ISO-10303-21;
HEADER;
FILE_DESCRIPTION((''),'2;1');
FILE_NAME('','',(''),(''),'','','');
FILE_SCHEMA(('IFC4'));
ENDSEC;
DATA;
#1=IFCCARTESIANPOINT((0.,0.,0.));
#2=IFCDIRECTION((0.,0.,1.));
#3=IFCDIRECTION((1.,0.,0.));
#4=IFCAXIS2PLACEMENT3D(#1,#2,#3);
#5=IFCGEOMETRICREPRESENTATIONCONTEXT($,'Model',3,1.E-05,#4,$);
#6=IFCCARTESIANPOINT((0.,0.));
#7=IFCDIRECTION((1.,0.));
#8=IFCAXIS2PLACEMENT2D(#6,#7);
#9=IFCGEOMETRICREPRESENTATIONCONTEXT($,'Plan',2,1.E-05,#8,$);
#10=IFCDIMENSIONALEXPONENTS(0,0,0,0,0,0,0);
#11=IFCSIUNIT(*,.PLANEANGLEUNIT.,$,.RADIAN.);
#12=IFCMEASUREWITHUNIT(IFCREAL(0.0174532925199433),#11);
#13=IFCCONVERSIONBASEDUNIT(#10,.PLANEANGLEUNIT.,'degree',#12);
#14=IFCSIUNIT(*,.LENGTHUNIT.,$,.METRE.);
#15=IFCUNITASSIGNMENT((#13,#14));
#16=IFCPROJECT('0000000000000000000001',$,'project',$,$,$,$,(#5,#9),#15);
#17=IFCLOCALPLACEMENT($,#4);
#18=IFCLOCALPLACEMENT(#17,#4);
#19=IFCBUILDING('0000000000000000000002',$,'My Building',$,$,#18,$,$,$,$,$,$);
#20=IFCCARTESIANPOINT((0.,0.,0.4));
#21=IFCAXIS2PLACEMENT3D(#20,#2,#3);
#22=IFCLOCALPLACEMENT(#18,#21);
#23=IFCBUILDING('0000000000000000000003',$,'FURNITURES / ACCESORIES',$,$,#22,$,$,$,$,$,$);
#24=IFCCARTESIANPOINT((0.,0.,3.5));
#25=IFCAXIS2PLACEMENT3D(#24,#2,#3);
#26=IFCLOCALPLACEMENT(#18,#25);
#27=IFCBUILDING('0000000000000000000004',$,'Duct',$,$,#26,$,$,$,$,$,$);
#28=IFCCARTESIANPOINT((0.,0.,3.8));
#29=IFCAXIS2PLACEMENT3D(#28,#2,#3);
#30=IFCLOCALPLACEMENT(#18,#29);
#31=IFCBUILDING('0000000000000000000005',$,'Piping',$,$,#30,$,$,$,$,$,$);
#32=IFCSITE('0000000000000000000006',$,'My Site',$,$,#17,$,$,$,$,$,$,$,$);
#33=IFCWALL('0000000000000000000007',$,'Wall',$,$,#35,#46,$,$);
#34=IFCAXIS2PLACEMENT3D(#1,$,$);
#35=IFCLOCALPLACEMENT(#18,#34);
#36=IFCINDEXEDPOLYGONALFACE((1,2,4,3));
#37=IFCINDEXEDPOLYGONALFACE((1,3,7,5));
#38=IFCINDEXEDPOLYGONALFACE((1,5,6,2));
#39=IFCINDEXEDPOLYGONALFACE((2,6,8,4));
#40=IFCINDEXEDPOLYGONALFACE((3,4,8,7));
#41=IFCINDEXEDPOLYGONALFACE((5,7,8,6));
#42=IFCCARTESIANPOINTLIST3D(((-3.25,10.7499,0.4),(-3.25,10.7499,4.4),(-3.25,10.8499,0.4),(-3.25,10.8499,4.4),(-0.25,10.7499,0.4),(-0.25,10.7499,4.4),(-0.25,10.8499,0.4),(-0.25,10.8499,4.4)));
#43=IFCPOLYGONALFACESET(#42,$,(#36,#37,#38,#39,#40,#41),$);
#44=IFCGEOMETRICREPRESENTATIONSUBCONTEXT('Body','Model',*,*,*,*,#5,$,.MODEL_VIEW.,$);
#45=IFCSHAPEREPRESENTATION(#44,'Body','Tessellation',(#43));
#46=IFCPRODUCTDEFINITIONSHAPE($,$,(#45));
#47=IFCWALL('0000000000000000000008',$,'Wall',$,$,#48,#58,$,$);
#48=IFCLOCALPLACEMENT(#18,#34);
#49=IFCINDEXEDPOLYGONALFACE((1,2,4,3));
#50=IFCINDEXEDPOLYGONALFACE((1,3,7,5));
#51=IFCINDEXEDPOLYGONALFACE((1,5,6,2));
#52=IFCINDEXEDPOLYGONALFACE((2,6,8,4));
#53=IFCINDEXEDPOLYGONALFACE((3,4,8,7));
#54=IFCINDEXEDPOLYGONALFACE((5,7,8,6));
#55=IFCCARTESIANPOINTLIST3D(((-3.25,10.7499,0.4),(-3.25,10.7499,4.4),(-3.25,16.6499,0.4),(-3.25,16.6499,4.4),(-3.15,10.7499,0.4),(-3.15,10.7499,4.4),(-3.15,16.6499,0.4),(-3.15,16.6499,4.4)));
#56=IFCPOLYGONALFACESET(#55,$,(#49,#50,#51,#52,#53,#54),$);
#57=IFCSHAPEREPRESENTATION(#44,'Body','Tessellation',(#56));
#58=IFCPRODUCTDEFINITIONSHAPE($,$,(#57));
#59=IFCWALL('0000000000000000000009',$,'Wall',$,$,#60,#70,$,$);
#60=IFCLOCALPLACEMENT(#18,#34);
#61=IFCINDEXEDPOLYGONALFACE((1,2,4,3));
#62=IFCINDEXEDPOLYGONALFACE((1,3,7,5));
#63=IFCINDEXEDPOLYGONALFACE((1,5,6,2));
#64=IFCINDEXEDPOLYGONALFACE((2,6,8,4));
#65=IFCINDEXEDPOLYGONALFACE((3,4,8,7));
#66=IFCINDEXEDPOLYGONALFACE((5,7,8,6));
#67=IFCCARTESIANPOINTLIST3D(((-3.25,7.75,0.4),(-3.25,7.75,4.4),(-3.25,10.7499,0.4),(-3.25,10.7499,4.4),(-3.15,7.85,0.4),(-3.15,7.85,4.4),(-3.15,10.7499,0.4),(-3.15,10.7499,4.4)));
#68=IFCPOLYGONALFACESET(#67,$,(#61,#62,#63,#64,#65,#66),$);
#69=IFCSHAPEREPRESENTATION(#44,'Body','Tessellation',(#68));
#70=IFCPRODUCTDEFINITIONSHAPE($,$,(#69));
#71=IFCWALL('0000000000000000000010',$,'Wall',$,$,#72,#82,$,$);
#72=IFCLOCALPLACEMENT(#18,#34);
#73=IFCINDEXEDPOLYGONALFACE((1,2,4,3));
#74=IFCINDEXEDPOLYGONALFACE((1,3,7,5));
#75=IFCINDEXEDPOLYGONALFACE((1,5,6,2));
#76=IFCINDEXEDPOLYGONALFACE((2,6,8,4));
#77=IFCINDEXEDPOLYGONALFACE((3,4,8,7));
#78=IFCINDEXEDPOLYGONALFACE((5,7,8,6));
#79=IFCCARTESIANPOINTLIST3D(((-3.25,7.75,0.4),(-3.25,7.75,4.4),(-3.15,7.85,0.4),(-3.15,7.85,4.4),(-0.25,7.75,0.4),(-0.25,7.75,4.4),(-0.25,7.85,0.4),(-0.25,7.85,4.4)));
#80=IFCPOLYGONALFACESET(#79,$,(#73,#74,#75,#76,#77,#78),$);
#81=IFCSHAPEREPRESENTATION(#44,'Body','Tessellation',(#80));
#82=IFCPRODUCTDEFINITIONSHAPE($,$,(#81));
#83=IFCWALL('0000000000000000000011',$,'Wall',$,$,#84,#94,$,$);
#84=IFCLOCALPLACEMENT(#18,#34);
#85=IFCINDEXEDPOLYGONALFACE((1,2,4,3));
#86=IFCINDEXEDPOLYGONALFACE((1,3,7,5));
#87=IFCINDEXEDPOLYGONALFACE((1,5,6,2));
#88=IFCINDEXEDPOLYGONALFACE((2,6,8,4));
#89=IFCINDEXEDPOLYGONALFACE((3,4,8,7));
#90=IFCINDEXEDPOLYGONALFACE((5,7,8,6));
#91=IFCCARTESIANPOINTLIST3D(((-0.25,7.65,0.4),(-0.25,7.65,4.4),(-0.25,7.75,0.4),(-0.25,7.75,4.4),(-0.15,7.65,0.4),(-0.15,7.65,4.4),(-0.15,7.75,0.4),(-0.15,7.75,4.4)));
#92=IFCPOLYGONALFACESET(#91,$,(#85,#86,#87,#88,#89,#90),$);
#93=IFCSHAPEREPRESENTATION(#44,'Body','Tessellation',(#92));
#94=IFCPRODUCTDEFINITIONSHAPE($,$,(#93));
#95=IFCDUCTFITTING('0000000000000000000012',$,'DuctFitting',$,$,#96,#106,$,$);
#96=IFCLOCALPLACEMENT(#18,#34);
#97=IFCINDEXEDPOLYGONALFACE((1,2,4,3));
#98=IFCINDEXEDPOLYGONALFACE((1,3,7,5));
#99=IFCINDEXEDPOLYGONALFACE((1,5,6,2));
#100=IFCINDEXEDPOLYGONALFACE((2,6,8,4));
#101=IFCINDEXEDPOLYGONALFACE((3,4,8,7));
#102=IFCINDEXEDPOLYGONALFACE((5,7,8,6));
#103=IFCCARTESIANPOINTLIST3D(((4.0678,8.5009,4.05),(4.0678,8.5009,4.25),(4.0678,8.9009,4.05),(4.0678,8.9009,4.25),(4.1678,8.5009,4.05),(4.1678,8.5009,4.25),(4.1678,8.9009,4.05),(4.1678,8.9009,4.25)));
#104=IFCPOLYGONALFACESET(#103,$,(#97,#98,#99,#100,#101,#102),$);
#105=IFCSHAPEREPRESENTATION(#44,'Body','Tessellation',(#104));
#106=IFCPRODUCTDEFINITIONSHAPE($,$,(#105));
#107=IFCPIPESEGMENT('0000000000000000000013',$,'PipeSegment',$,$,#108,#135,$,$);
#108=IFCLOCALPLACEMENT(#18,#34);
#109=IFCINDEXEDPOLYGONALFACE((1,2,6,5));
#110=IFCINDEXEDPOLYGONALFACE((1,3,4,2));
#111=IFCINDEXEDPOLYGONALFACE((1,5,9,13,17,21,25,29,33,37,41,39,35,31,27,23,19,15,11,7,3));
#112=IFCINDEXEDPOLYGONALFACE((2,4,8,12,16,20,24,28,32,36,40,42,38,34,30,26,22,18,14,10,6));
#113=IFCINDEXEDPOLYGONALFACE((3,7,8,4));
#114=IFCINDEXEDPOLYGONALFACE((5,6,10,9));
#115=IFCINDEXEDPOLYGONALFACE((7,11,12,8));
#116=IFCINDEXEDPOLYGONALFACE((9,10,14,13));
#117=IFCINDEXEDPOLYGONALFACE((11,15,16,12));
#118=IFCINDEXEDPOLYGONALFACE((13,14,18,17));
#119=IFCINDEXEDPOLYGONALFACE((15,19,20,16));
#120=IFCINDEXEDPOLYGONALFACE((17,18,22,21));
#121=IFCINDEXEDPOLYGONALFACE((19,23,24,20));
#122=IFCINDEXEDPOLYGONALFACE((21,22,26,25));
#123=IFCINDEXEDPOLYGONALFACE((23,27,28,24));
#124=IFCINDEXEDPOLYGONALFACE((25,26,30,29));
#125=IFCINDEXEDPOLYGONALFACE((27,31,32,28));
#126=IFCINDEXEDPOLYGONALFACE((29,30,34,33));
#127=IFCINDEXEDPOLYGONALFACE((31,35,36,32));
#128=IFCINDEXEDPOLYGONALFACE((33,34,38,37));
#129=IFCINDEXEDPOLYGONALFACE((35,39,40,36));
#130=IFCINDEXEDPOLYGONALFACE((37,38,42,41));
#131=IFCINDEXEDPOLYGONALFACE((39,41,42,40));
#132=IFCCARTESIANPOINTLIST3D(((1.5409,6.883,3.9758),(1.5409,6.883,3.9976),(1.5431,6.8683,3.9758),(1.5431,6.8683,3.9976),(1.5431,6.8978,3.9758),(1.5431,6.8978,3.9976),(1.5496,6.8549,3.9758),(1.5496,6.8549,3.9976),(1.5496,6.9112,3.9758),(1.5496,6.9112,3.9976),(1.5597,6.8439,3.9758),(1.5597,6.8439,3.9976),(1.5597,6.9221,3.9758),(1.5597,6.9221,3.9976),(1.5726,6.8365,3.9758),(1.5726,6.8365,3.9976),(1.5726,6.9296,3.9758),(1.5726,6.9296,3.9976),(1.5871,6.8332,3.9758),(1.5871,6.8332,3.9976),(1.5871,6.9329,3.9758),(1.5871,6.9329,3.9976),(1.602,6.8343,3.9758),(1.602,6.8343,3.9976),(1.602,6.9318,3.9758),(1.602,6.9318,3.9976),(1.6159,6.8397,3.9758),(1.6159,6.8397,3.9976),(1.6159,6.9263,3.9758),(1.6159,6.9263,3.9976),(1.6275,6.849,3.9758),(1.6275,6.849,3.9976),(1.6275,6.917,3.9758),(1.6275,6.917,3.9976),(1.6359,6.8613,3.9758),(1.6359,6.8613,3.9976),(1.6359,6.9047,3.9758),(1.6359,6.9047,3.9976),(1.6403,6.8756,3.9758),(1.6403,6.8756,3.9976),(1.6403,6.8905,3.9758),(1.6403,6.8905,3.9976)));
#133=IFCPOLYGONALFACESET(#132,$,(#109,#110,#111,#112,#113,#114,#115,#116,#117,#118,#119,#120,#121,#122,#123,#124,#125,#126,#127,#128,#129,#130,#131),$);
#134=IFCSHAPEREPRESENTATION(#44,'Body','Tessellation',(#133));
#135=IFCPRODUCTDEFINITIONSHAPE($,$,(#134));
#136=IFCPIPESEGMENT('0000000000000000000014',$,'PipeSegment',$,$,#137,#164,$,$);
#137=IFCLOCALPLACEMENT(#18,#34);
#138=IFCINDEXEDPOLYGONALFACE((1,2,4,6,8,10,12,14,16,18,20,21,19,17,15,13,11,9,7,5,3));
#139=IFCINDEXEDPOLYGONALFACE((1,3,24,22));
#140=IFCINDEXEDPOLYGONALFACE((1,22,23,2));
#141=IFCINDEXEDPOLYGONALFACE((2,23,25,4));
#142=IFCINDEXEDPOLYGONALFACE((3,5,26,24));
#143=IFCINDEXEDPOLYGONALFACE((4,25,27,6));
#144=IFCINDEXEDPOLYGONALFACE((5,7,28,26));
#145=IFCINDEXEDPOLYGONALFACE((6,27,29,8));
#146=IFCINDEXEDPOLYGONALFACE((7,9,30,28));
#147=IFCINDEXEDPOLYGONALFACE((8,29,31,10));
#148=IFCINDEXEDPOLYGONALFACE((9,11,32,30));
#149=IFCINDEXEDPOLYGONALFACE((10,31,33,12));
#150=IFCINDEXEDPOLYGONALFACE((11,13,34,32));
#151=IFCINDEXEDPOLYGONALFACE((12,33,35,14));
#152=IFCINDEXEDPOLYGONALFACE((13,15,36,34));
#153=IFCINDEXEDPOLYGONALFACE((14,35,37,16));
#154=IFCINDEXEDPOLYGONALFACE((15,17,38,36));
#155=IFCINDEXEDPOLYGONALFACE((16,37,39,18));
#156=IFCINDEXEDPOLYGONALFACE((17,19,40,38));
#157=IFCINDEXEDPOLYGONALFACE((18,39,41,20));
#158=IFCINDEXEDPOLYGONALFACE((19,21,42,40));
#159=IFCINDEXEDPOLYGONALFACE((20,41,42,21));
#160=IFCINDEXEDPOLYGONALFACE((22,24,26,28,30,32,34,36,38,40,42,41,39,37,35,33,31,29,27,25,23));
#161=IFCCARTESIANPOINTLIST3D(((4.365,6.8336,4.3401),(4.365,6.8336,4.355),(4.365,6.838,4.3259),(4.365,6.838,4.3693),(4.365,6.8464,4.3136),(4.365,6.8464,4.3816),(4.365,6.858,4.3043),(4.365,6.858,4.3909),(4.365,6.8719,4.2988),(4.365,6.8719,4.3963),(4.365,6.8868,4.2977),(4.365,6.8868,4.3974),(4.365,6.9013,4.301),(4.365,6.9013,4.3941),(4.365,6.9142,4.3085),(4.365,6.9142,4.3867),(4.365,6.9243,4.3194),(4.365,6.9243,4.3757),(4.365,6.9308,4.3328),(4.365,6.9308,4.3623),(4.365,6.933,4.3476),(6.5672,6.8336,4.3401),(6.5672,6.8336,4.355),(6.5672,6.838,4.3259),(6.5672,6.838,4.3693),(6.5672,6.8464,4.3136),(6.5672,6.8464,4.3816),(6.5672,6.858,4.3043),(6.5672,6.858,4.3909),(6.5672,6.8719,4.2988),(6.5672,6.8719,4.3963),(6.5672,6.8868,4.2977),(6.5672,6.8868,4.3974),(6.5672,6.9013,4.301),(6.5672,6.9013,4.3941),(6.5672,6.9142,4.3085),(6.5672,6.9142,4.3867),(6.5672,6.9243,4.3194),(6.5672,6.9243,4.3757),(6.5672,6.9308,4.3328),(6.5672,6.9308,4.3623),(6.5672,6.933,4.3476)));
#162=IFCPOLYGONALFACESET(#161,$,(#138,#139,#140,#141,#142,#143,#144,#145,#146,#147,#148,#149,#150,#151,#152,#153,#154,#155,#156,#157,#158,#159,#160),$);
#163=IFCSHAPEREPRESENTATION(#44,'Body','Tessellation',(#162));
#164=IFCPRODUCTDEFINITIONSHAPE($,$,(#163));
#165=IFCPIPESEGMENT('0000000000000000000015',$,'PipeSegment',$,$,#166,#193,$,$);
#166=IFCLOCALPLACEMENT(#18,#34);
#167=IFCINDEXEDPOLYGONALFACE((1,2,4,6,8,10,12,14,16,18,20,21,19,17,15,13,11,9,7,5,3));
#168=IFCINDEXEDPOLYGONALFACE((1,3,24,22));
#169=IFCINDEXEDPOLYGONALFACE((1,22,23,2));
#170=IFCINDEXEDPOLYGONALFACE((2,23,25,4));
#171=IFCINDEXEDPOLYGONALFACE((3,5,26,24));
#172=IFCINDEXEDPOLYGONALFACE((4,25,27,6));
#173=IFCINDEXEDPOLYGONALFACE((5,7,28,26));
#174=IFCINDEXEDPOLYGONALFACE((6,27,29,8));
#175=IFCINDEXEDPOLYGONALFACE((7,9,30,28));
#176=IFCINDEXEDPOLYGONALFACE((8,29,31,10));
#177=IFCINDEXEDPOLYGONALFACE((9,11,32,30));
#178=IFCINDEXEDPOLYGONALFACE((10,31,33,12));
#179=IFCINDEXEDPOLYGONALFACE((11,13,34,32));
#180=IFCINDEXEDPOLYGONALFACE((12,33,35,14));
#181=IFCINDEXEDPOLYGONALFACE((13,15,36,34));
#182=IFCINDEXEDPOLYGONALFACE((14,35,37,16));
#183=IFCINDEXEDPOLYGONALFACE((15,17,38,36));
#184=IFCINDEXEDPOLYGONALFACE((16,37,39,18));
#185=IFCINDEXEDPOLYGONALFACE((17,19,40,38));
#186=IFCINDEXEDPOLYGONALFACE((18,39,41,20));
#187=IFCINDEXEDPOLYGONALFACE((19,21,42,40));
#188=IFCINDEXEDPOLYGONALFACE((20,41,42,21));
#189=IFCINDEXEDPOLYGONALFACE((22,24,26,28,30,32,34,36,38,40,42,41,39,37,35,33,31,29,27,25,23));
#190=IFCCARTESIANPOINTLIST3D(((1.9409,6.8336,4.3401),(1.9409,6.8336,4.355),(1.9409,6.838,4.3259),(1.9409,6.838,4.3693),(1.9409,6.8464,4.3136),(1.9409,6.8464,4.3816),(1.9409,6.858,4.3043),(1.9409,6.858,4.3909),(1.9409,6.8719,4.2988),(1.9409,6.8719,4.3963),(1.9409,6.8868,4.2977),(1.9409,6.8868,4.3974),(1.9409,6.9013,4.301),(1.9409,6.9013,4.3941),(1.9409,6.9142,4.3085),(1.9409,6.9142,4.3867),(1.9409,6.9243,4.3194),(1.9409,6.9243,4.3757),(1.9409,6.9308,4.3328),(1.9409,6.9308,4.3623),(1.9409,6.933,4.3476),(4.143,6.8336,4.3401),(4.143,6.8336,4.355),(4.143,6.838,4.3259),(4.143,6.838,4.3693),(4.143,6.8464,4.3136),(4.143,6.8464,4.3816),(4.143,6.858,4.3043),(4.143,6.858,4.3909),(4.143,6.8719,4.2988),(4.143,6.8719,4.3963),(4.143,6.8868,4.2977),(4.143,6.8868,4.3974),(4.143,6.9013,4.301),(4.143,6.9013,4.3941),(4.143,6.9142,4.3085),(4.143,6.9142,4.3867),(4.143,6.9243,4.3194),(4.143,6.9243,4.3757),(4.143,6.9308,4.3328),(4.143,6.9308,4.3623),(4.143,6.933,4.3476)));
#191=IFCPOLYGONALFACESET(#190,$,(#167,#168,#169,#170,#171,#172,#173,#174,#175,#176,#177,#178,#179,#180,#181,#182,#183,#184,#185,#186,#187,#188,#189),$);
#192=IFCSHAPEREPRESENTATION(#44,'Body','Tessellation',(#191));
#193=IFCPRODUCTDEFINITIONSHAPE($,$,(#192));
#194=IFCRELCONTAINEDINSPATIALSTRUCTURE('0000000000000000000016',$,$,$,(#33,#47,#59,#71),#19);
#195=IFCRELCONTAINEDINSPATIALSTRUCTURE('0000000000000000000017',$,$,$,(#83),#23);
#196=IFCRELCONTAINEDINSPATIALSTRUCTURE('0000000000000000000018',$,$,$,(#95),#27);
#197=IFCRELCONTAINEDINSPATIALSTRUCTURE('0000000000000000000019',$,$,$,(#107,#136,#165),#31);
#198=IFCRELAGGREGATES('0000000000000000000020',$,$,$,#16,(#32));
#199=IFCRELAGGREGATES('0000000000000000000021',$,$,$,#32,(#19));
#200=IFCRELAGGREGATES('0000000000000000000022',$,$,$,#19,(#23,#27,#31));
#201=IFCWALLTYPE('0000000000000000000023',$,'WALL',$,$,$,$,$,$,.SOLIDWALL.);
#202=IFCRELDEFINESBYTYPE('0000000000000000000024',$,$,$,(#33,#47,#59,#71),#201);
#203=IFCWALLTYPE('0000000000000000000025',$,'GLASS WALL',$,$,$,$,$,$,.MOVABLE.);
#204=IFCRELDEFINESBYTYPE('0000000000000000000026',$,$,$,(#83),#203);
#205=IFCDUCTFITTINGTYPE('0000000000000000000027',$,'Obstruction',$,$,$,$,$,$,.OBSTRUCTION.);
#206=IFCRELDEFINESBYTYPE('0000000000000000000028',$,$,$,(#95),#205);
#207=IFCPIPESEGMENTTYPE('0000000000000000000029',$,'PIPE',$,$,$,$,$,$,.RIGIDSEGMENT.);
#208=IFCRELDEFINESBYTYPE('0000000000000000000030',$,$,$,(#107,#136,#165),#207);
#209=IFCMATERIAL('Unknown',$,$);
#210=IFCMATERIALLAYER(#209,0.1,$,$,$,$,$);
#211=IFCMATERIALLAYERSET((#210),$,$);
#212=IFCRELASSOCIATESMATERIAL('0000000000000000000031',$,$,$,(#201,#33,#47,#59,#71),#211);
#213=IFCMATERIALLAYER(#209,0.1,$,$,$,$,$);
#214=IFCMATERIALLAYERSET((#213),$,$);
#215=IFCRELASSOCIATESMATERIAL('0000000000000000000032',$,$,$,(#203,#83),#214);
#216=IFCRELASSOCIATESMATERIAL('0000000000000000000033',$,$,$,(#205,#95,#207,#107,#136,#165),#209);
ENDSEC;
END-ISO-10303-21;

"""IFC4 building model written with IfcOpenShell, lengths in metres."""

from ifc_helpers import new_model, entity, si_unit, converted_unit, frame, origin_with_axes, origin_2d_with_axis, place, context, subcontext, project, spatial, line, indexed_curve, rectangle, circle, outline, extrude, material, layer, layer_set, layer_usage, material_profile, profile_set, profile_usage, type_object, element, save


model = new_model("IFC4")

# Units and contexts
model_context = context("Model", 3, precision=1e-05, world=origin_with_axes())
plan_context = context("Plan", 2, precision=1e-05, world=origin_2d_with_axis())
body_context = subcontext(model_context, "Body", "Model", "MODEL_VIEW")
ifc_project = project(units=[converted_unit("PLANEANGLEUNIT", "degree", entity("IfcReal", 0.0174532925199433), si_unit("PLANEANGLEUNIT", "RADIAN"), dimensions=[0, 0, 0, 0, 0, 0, 0]), si_unit("LENGTHUNIT", "METRE")], contexts=[model_context, plan_context])

# Site, building
site_placement = place(None, origin_with_axes())
site = spatial("IfcSite", under=ifc_project, at=site_placement, Name="My Site")
building_1_placement = place(site_placement, origin_with_axes())
building_1 = spatial("IfcBuilding", under=site, at=building_1_placement, Name="My Building")

# Walls
ifc_material = material(Name="Unknown")
ifc_layer_1 = layer(ifc_material, 0.1)
ifc_layer_set_1 = layer_set([ifc_layer_1])
ifc_layer_usage_1 = layer_usage(ifc_layer_set_1, "AXIS2", "POSITIVE", 0.0)
wall_type_1 = type_object("IfcWallType", Name="WALL", PredefinedType="SOLIDWALL", material=ifc_layer_set_1)
wall_1_placement = place(building_1_placement, frame((-3.25, 10.7499, 0.4), z_axis=(0.0, 0.0, 1.0), x_axis=(1.0, 0.0, 0.0)))
element("IfcWall", 1, at=wall_1_placement, inside=building_1, type_object=wall_type_1, material=ifc_layer_usage_1, Name="Wall", context=body_context, shape_type="SweptSolid", body=[
    extrude(outline(indexed_curve([(0.0, 0.0), (0.0, 0.1), (3.0, 0.1), (3.0, 0.0)], segments=[line(1, 2, 3, 4, 1)])), origin_with_axes(), (0.0, 0.0, 1.0), 4.0),
])
ifc_layer_usage_2 = layer_usage(ifc_layer_set_1, "AXIS2", "POSITIVE", 0.0)
wall_2_placement = place(building_1_placement, frame((-3.15, 10.7499, 0.4), z_axis=(0.0, 0.0, 1.0), x_axis=(0.0, 1.0, 0.0)))
element("IfcWall", 2, at=wall_2_placement, inside=building_1, type_object=wall_type_1, material=ifc_layer_usage_2, Name="Wall", context=body_context, shape_type="SweptSolid", body=[
    extrude(outline(indexed_curve([(0.0, 0.0), (0.0, 0.1), (5.9, 0.1), (5.9, 0.0)], segments=[line(1, 2, 3, 4, 1)])), origin_with_axes(), (0.0, 0.0, 1.0), 4.0),
])
ifc_layer_usage_3 = layer_usage(ifc_layer_set_1, "AXIS2", "POSITIVE", 0.0)
wall_3_placement = place(building_1_placement, frame((-3.25, 10.7499, 0.4), z_axis=(0.0, 0.0, 1.0), x_axis=(0.0, -1.0, 0.0)))
element("IfcWall", 3, at=wall_3_placement, inside=building_1, type_object=wall_type_1, material=ifc_layer_usage_3, Name="Wall", context=body_context, shape_type="SweptSolid", body=[
    extrude(outline(indexed_curve([(0.0, 0.0), (0.0, 0.1), (2.8999, 0.1), (2.9999, 0.0)], segments=[line(1, 2, 3, 4, 1)])), origin_with_axes(), (0.0, 0.0, 1.0), 4.0),
])
ifc_layer_usage_4 = layer_usage(ifc_layer_set_1, "AXIS2", "POSITIVE", 0.0)
wall_4_placement = place(building_1_placement, frame((-3.25, 7.75, 0.4), z_axis=(0.0, 0.0, 1.0), x_axis=(1.0, 0.0, 0.0)))
element("IfcWall", 4, at=wall_4_placement, inside=building_1, type_object=wall_type_1, material=ifc_layer_usage_4, Name="Wall", context=body_context, shape_type="SweptSolid", body=[
    extrude(outline(indexed_curve([(0.0, 0.0), (0.1, 0.1), (3.0, 0.1), (3.0, 0.0)], segments=[line(1, 2, 3, 4, 1)])), origin_with_axes(), (0.0, 0.0, 1.0), 4.0),
])

# Shared definitions
building_2_placement = place(building_1_placement, frame((0.0, 0.0, 0.4), z_axis=(0.0, 0.0, 1.0), x_axis=(1.0, 0.0, 0.0)))
building_2 = spatial("IfcBuilding", under=building_1, at=building_2_placement, Name="FURNITURES / ACCESORIES")

# Wall
ifc_layer_2 = layer(ifc_material, 0.1)
ifc_layer_set_2 = layer_set([ifc_layer_2])
ifc_layer_usage_5 = layer_usage(ifc_layer_set_2, "AXIS2", "POSITIVE", 0.0)
wall_type_2 = type_object("IfcWallType", Name="GLASS WALL", PredefinedType="MOVABLE", material=ifc_layer_set_2)
wall_5_placement = place(building_2_placement, frame((-0.25, 7.65, 0.0), z_axis=(0.0, 0.0, 1.0), x_axis=(1.0, 0.0, 0.0)))
element("IfcWall", 5, at=wall_5_placement, inside=building_2, type_object=wall_type_2, material=ifc_layer_usage_5, Name="Wall", context=body_context, shape_type="SweptSolid", body=[
    extrude(outline(indexed_curve([(0.0, 0.0), (0.0, 0.1), (0.1, 0.1), (0.1, 0.0)], segments=[line(1, 2, 3, 4, 1)])), origin_with_axes(), (0.0, 0.0, 1.0), 4.0),
])

# Shared definitions
building_3_placement = place(building_1_placement, frame((0.0, 0.0, 3.5), z_axis=(0.0, 0.0, 1.0), x_axis=(1.0, 0.0, 0.0)))
building_3 = spatial("IfcBuilding", under=building_1, at=building_3_placement, Name="Duct")

# Duct fitting
ifc_material_profile_1 = material_profile(ifc_material, rectangle(XDim=0.4, YDim=0.2))
ifc_profile_set_1 = profile_set([ifc_material_profile_1])
ifc_profile_usage_1 = profile_usage(ifc_profile_set_1, cardinal=5)
duct_fitting_type = type_object("IfcDuctFittingType", Name="Obstruction", PredefinedType="OBSTRUCTION", material=ifc_profile_set_1)
duct_fitting_placement = place(building_3_placement, frame((4.1678, 8.7009, 0.65), z_axis=(-1.0, 0.0, 0.0), x_axis=(0.0, 1.0, 0.0)))
element("IfcDuctFitting", 6, at=duct_fitting_placement, inside=building_3, type_object=duct_fitting_type, material=ifc_profile_usage_1, Name="DuctFitting", context=body_context, shape_type="SweptSolid", body=[
    extrude(rectangle(XDim=0.4, YDim=0.2), origin_with_axes(), (0.0, 0.0, 1.0), 0.1),
])

# Shared definitions
building_4_placement = place(building_1_placement, frame((0.0, 0.0, 3.8), z_axis=(0.0, 0.0, 1.0), x_axis=(1.0, 0.0, 0.0)))
building_4 = spatial("IfcBuilding", under=building_1, at=building_4_placement, Name="Piping")

# Pipe segments
ifc_material_profile_2 = material_profile(ifc_material, circle(Radius=0.05))
ifc_profile_set_2 = profile_set([ifc_material_profile_2])
ifc_profile_usage_2 = profile_usage(ifc_profile_set_2, cardinal=5)
pipe_segment_type = type_object("IfcPipeSegmentType", Name="PIPE", PredefinedType="RIGIDSEGMENT", material=ifc_profile_set_2)
pipe_segment_1_placement = place(building_4_placement, frame((1.5909, 6.883, 0.1976), z_axis=(0.0, 0.0, -1.0), x_axis=(-1.0, 0.0, 0.0)))
element("IfcPipeSegment", 7, at=pipe_segment_1_placement, inside=building_4, type_object=pipe_segment_type, material=ifc_profile_usage_2, Name="PipeSegment", context=body_context, shape_type="SweptSolid", body=[
    extrude(circle(Radius=0.05), origin_with_axes(), (0.0, 0.0, 1.0), 0.0218),
])
ifc_profile_usage_3 = profile_usage(ifc_profile_set_2, cardinal=5)
pipe_segment_2_placement = place(building_4_placement, frame((4.365, 6.883, 0.5476), z_axis=(1.0, -0.000001, 0.000001), x_axis=(0.000001, 1.0, 0.0)))
element("IfcPipeSegment", 8, at=pipe_segment_2_placement, inside=building_4, type_object=pipe_segment_type, material=ifc_profile_usage_3, Name="PipeSegment", context=body_context, shape_type="SweptSolid", body=[
    extrude(circle(Radius=0.05), origin_with_axes(), (0.0, 0.0, 1.0), 2.2022),
])
ifc_profile_usage_4 = profile_usage(ifc_profile_set_2, cardinal=5)
pipe_segment_3_placement = place(building_4_placement, frame((4.143, 6.883, 0.5476), z_axis=(-1.0, -0.000001, -0.000001), x_axis=(-0.000001, 1.0, 0.0)))
element("IfcPipeSegment", 9, at=pipe_segment_3_placement, inside=building_4, type_object=pipe_segment_type, material=ifc_profile_usage_4, Name="PipeSegment", context=body_context, shape_type="SweptSolid", body=[
    extrude(circle(Radius=0.05), origin_with_axes(), (0.0, 0.0, 1.0), 2.2022),
])

save(model, "model.ifc")
